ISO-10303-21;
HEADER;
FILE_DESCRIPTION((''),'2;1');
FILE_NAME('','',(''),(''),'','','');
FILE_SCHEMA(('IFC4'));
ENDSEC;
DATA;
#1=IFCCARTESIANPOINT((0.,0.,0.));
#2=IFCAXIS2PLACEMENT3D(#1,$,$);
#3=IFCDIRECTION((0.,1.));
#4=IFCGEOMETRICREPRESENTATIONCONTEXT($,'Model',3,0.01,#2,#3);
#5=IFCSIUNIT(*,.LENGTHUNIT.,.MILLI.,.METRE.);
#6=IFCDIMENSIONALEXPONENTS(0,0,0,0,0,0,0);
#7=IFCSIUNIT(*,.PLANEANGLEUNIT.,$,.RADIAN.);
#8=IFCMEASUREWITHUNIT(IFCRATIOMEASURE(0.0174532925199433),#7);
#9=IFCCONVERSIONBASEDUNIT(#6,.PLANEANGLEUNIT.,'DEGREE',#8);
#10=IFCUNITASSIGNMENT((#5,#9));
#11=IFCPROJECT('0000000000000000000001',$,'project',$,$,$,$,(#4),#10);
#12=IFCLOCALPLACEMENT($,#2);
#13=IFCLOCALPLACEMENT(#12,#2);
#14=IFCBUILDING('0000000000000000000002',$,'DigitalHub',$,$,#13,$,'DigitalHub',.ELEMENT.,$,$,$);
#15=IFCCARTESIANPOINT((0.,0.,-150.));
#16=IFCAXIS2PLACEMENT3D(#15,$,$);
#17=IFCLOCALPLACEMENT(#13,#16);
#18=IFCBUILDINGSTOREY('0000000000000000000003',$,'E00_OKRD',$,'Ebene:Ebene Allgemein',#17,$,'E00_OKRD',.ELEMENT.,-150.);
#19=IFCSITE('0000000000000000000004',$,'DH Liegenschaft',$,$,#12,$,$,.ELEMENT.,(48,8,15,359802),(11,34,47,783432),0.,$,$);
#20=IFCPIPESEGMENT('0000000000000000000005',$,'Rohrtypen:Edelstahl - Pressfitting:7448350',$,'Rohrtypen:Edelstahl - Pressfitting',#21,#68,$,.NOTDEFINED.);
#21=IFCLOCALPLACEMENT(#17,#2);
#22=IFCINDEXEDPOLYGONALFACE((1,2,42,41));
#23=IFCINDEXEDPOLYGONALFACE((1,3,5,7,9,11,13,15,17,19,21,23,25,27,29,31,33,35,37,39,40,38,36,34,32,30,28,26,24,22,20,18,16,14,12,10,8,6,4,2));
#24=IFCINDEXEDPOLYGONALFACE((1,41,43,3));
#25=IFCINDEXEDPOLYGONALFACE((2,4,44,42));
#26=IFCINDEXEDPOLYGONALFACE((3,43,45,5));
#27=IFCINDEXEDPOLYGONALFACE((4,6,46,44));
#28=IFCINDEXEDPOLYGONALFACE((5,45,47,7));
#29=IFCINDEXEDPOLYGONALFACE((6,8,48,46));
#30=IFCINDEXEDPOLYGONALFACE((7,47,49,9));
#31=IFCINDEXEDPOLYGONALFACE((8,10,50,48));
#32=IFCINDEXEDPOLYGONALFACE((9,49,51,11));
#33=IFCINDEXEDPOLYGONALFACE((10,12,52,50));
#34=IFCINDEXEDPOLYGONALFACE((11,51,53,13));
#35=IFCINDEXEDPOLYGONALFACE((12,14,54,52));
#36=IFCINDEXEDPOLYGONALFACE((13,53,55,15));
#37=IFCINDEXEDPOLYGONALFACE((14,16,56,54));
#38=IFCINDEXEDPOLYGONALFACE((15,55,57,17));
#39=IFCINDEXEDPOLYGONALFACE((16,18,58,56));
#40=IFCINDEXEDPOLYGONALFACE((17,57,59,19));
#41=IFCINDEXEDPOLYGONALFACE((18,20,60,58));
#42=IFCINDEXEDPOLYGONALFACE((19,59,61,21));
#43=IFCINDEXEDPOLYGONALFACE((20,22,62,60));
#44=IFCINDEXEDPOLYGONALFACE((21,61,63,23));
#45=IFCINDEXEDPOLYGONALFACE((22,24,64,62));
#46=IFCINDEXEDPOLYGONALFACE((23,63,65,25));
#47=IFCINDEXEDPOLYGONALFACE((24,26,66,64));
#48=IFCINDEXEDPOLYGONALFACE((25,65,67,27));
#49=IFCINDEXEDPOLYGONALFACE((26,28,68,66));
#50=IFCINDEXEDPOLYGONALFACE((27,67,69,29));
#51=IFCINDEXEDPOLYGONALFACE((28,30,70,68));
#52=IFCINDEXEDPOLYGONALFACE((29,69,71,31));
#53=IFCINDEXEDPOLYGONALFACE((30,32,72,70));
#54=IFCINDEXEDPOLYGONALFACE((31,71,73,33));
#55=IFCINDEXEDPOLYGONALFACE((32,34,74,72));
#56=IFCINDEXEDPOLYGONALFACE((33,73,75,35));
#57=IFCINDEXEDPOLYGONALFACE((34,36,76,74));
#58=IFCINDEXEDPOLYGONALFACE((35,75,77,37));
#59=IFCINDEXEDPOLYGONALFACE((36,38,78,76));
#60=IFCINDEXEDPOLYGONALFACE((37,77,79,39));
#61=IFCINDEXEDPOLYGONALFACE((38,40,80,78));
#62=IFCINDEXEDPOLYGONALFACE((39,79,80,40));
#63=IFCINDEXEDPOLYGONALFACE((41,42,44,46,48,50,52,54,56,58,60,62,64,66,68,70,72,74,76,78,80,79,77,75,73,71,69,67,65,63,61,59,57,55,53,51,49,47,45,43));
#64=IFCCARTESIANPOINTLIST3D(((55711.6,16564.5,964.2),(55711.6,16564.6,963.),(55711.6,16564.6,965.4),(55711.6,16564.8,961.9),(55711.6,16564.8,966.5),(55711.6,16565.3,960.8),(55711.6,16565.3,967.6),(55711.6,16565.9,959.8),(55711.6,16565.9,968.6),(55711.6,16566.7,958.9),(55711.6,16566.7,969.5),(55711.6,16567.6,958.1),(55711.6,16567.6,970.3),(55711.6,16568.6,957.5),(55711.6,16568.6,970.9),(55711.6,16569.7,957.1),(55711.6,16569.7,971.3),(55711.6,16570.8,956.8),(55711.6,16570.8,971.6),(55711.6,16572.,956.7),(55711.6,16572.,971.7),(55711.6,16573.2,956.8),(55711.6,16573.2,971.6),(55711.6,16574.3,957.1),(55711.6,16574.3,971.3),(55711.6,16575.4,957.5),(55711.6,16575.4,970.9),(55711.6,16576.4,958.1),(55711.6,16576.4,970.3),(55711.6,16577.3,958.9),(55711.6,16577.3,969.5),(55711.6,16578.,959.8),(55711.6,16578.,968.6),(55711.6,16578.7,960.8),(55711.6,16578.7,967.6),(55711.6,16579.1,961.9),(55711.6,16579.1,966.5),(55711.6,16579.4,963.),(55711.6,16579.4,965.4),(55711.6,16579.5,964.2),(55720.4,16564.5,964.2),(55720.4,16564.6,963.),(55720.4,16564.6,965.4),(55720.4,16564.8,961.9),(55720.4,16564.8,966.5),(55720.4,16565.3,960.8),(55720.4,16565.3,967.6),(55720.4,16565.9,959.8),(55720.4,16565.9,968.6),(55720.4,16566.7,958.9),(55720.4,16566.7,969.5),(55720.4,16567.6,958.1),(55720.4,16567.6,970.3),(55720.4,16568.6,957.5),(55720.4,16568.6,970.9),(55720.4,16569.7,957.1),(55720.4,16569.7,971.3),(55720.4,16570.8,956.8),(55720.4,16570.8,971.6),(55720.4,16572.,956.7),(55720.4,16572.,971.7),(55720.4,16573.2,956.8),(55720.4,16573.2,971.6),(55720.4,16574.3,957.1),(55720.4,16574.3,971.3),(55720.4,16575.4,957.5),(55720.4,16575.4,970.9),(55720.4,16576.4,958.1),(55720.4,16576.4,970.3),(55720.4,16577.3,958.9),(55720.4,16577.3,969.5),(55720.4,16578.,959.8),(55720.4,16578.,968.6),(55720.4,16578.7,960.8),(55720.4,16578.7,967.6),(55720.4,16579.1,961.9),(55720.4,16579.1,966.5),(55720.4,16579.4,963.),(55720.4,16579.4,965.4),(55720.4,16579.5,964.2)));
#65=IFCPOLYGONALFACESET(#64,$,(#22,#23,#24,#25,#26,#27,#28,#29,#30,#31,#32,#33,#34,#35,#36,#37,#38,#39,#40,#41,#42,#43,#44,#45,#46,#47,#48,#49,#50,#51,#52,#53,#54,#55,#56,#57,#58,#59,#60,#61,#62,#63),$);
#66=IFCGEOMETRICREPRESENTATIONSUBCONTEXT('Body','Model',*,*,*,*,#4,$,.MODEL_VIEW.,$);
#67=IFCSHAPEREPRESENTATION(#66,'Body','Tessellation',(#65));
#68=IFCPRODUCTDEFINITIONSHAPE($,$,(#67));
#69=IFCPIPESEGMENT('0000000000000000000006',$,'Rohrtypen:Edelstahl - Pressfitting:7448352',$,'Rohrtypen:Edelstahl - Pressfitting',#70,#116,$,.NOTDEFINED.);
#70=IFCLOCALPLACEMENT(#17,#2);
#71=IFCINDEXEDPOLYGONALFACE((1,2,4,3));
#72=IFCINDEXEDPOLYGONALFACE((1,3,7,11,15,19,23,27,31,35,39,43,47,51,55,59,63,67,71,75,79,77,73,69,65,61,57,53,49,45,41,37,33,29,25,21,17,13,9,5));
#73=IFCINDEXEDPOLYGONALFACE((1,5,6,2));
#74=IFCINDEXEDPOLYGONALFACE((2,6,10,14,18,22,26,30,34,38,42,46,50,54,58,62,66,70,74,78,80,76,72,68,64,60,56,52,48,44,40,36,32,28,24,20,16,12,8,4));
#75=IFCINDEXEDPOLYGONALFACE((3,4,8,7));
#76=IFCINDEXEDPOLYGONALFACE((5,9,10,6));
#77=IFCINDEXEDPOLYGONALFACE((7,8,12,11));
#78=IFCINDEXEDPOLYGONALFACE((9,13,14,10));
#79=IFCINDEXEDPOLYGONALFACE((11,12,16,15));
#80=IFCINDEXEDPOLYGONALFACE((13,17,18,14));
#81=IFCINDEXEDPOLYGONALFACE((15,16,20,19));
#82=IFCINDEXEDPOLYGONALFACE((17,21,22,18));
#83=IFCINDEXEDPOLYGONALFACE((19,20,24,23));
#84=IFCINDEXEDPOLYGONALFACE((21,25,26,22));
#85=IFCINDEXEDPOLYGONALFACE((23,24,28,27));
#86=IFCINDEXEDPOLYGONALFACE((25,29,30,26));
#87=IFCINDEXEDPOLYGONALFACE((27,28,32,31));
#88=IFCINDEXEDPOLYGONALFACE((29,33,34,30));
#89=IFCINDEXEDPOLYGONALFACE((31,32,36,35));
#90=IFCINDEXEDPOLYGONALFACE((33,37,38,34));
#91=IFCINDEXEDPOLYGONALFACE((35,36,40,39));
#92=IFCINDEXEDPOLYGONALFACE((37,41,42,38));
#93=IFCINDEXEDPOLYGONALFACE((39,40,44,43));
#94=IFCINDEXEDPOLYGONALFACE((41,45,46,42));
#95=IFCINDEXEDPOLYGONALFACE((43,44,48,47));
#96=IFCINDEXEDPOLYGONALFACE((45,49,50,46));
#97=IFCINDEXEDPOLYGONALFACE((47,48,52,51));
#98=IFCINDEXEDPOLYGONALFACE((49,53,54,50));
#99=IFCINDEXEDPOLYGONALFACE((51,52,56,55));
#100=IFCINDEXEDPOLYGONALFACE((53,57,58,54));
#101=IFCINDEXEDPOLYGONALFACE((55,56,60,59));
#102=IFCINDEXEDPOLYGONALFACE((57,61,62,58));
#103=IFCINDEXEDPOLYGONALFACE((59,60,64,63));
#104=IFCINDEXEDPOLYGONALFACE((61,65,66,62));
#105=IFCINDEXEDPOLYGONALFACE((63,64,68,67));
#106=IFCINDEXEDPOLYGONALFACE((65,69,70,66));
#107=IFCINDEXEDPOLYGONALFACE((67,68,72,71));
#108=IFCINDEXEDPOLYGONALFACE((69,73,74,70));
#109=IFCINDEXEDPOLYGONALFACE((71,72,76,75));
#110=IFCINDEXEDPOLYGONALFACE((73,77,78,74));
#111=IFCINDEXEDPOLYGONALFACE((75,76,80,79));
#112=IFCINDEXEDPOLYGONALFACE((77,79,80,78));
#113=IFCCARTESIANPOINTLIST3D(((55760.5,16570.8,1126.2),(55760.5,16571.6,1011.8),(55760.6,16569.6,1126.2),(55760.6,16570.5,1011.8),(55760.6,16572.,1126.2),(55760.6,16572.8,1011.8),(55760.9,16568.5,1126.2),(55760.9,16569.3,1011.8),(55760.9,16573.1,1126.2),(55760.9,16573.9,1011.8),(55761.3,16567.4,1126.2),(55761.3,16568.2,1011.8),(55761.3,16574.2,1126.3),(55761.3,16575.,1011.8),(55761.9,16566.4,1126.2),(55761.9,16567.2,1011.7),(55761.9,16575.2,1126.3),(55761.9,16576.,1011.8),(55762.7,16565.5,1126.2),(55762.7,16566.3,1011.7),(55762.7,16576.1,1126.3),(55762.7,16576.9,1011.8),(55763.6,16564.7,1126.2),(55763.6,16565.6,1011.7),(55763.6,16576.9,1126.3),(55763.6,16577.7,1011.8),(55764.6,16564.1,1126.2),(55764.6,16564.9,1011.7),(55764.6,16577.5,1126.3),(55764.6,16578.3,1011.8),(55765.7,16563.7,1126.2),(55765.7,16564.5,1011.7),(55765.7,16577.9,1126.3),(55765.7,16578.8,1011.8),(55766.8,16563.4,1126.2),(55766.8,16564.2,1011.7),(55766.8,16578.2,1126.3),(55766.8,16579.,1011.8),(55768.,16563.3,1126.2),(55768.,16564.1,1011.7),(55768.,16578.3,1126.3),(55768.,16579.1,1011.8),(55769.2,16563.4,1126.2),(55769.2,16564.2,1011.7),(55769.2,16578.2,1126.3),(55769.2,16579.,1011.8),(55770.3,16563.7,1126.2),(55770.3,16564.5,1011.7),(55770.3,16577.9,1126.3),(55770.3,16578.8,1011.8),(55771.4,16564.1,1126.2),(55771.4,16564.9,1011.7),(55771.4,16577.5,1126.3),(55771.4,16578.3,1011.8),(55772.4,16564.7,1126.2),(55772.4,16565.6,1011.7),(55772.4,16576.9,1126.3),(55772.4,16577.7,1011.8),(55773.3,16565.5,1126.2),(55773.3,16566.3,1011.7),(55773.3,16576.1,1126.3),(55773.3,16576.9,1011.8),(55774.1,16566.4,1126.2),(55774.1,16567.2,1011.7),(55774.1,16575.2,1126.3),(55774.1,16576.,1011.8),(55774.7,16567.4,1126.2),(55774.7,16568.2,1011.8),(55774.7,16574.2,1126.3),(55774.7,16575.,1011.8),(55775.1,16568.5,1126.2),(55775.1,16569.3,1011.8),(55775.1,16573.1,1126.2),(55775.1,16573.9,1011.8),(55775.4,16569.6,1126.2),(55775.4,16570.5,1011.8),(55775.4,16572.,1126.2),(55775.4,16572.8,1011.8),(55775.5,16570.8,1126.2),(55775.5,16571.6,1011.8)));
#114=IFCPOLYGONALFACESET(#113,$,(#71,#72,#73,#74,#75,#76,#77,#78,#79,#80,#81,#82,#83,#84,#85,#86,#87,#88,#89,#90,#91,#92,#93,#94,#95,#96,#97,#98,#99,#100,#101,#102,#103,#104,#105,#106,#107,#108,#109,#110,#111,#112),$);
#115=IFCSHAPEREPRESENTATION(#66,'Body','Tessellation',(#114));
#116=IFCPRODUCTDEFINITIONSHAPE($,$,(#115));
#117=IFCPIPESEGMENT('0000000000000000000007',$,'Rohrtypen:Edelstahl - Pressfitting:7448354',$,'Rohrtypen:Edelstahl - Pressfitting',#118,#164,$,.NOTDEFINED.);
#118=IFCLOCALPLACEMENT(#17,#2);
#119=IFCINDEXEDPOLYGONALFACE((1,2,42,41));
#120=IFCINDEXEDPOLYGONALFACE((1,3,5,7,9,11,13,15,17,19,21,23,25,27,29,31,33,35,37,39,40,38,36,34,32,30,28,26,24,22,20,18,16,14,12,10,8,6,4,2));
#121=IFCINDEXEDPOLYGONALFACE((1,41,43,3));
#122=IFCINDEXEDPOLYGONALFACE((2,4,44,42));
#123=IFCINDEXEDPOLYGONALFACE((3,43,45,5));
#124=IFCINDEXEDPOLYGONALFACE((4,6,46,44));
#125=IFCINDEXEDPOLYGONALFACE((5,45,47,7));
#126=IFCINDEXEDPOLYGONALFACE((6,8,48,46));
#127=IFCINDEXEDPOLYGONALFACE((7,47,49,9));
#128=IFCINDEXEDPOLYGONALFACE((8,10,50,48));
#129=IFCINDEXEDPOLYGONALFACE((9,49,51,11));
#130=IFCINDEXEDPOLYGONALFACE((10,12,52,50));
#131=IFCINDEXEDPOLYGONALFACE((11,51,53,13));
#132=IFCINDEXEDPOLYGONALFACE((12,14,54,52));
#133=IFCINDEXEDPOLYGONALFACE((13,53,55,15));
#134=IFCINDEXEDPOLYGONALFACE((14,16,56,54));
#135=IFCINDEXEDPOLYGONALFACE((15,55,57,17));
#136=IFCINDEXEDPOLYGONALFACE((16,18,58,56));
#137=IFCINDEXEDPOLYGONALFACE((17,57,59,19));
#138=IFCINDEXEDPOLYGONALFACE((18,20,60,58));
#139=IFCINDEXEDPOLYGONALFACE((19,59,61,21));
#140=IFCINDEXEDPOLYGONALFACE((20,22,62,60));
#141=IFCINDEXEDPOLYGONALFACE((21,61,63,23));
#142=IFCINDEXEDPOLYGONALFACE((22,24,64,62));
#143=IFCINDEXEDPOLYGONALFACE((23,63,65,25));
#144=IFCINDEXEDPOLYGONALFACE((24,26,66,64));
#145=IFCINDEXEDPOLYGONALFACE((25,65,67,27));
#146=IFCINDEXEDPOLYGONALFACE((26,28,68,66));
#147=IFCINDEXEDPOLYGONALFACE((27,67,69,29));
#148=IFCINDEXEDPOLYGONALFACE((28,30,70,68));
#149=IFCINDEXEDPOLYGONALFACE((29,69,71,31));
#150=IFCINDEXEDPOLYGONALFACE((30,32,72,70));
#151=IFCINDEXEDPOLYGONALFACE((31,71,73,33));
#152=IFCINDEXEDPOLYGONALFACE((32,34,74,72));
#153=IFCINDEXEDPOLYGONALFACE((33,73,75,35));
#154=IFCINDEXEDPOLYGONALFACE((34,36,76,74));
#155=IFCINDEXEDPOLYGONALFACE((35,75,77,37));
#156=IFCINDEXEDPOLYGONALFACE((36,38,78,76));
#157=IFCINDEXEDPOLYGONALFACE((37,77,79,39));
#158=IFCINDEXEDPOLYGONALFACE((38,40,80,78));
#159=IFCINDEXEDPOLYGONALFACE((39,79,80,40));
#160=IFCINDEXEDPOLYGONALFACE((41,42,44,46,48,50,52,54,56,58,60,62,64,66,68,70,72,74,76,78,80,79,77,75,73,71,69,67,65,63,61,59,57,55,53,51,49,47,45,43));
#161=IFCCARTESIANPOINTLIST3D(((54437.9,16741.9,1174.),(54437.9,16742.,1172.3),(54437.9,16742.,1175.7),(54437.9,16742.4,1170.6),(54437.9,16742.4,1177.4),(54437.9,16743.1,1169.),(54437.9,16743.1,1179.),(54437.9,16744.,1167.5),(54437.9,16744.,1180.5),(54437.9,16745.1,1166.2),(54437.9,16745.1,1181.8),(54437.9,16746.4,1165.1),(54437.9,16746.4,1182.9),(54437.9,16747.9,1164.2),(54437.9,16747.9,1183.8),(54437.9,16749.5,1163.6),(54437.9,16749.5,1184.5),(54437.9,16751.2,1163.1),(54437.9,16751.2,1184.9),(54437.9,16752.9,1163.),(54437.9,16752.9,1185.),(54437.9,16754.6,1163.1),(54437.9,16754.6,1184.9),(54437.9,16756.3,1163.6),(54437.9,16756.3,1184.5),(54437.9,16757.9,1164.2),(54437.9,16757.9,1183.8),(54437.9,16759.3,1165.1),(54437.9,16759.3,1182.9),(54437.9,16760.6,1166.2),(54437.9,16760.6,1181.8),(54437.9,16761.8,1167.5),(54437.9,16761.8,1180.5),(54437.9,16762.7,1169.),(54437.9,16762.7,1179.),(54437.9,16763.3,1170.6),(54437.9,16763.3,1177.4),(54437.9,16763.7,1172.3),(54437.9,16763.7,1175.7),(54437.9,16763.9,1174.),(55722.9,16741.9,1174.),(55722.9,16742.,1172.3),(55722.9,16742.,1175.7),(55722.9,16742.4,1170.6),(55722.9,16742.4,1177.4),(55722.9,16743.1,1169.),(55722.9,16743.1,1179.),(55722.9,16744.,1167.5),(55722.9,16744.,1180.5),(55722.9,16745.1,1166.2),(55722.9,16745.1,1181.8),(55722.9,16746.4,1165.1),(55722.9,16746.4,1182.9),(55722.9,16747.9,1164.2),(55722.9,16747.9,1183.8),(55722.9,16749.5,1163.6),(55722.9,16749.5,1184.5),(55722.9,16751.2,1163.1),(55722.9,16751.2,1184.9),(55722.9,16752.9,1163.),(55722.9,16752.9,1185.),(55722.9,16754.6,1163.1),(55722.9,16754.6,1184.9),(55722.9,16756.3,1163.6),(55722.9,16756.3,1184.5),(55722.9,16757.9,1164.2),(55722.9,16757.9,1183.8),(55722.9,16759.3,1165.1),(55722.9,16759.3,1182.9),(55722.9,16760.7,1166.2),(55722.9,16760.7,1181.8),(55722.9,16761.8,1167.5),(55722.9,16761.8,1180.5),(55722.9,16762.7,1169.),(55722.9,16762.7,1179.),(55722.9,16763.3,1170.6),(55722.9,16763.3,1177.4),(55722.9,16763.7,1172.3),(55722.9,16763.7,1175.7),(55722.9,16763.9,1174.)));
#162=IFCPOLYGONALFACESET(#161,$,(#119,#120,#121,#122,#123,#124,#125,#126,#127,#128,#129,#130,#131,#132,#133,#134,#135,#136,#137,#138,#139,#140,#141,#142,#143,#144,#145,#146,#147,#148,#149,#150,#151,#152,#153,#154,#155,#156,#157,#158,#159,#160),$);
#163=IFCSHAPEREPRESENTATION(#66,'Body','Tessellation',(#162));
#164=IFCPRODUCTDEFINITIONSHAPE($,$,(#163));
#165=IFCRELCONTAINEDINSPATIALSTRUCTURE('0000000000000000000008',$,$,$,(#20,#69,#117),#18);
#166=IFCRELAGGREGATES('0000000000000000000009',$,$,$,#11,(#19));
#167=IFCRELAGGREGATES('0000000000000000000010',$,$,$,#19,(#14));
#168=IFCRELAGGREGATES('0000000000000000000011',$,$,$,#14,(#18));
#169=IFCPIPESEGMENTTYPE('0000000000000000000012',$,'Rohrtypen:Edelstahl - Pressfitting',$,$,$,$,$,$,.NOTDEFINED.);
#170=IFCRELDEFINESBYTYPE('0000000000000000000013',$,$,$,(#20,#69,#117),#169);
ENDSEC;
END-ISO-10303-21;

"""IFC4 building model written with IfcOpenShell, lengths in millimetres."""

from ifc_helpers import new_model, entity, si_unit, converted_unit, direction, frame, origin, place, context, subcontext, project, spatial, indexed_curve, outline, extrude, type_object, element, save


model = new_model("IFC4")

# Units and contexts
model_context = context("Model", 3, precision=0.01, world=origin(), true_north=direction((0.0, 1.0)))
body_context = subcontext(model_context, "Body", "Model", "MODEL_VIEW")
ifc_project = project(units=[si_unit("LENGTHUNIT", "METRE", prefix="MILLI"), converted_unit("PLANEANGLEUNIT", "DEGREE", entity("IfcRatioMeasure", 0.0174532925199433), si_unit("PLANEANGLEUNIT", "RADIAN"), dimensions=[0, 0, 0, 0, 0, 0, 0])], contexts=[model_context])

# Site, building, storey
site_placement = place(None, origin())
site = spatial("IfcSite", under=ifc_project, at=site_placement, Name="DH Liegenschaft", CompositionType="ELEMENT", RefLatitude=(48, 8, 15, 359802), RefLongitude=(11, 34, 47, 783432), RefElevation=0.0)
building_placement = place(site_placement, origin())
building = spatial("IfcBuilding", under=site, at=building_placement, Name="DigitalHub", LongName="DigitalHub", CompositionType="ELEMENT")
storey_placement = place(building_placement, frame((0.0, 0.0, -150.0)))
storey = spatial("IfcBuildingStorey", under=building, at=storey_placement, Name="E00_OKRD", ObjectType="Ebene:Ebene Allgemein", LongName="E00_OKRD", CompositionType="ELEMENT", Elevation=-150.0)

# Pipe segments
pipe_segment_type_1 = type_object("IfcPipeSegmentType", Name="Rohrtypen:Edelstahl - Pressfitting", PredefinedType="NOTDEFINED")
pipe_segment_1_placement = place(storey_placement, frame((55711.6, 16562.9, 955.1)))
element("IfcPipeSegment", 1, at=pipe_segment_1_placement, inside=storey, type_object=pipe_segment_type_1, Name="Rohrtypen:Edelstahl - Pressfitting:7448350", ObjectType="Rohrtypen:Edelstahl - Pressfitting", PredefinedType="NOTDEFINED", context=body_context, shape_type="SweptSolid", body=[
    extrude(outline(indexed_curve([(7.5, 0.0), (7.4, 1.2), (7.1, 2.3), (6.7, 3.4), (6.1, 4.4), (5.3, 5.3), (4.4, 6.1), (3.4, 6.7), (2.3, 7.1), (1.2, 7.4), (0.0, 7.5), (-1.2, 7.4), (-2.3, 7.1), (-3.4, 6.7), (-4.4, 6.1), (-5.3, 5.3), (-6.1, 4.4), (-6.7, 3.4), (-7.1, 2.3), (-7.4, 1.2), (-7.5, 0.0), (-7.4, -1.2), (-7.1, -2.3), (-6.7, -3.4), (-6.1, -4.4), (-5.3, -5.3), (-4.4, -6.1), (-3.4, -6.7), (-2.3, -7.1), (-1.2, -7.4), (0.0, -7.5), (1.2, -7.4), (2.3, -7.1), (3.4, -6.7), (4.4, -6.1), (5.3, -5.3), (6.1, -4.4), (6.7, -3.4), (7.1, -2.3), (7.4, -1.2), (7.5, 0.0)], self_intersect=False)), frame((0.0, 9.1, 9.1), z_axis=(1.0, -0.000009, 0.0), x_axis=(-0.000009, -1.0, 0.0)), (0.0, 0.0, 1.0), 8.8),
])
pipe_segment_2_placement = place(storey_placement, frame((55758.9, 16561.7, 1011.7)))
element("IfcPipeSegment", 2, at=pipe_segment_2_placement, inside=storey, type_object=pipe_segment_type_1, Name="Rohrtypen:Edelstahl - Pressfitting:7448352", ObjectType="Rohrtypen:Edelstahl - Pressfitting", PredefinedType="NOTDEFINED", context=body_context, shape_type="SweptSolid", body=[
    extrude(outline(indexed_curve([(7.5, 0.0), (7.4, 1.2), (7.1, 2.3), (6.7, 3.4), (6.1, 4.4), (5.3, 5.3), (4.4, 6.1), (3.4, 6.7), (2.3, 7.1), (1.2, 7.4), (0.0, 7.5), (-1.2, 7.4), (-2.3, 7.1), (-3.4, 6.7), (-4.4, 6.1), (-5.3, 5.3), (-6.1, 4.4), (-6.7, 3.4), (-7.1, 2.3), (-7.4, 1.2), (-7.5, 0.0), (-7.4, -1.2), (-7.1, -2.3), (-6.7, -3.4), (-6.1, -4.4), (-5.3, -5.3), (-4.4, -6.1), (-3.4, -6.7), (-2.3, -7.1), (-1.2, -7.4), (0.0, -7.5), (1.2, -7.4), (2.3, -7.1), (3.4, -6.7), (4.4, -6.1), (5.3, -5.3), (6.1, -4.4), (6.7, -3.4), (7.1, -2.3), (7.4, -1.2), (7.5, 0.0)], self_intersect=False)), frame((9.1, 9.9, 0.1), z_axis=(0.0, -0.007378, 0.999973), x_axis=(-1.0, 0.0, 0.0)), (0.0, 0.0, 1.0), 114.4),
])
pipe_segment_3_placement = place(storey_placement, frame((54437.9, 16740.3, 1161.4)))
element("IfcPipeSegment", 3, at=pipe_segment_3_placement, inside=storey, type_object=pipe_segment_type_1, Name="Rohrtypen:Edelstahl - Pressfitting:7448354", ObjectType="Rohrtypen:Edelstahl - Pressfitting", PredefinedType="NOTDEFINED", context=body_context, shape_type="SweptSolid", body=[
    extrude(outline(indexed_curve([(11.0, 0.0), (10.9, 1.7), (10.5, 3.4), (9.8, 5.0), (8.9, 6.5), (7.8, 7.8), (6.5, 8.9), (5.0, 9.8), (3.4, 10.5), (1.7, 10.9), (0.0, 11.0), (-1.7, 10.9), (-3.4, 10.5), (-5.0, 9.8), (-6.5, 8.9), (-7.8, 7.8), (-8.9, 6.5), (-9.8, 5.0), (-10.5, 3.4), (-10.9, 1.7), (-11.0, 0.0), (-10.9, -1.7), (-10.5, -3.4), (-9.8, -5.0), (-8.9, -6.5), (-7.8, -7.8), (-6.5, -8.9), (-5.0, -9.8), (-3.4, -10.5), (-1.7, -10.9), (0.0, -11.0), (1.7, -10.9), (3.4, -10.5), (5.0, -9.8), (6.5, -8.9), (7.8, -7.8), (8.9, -6.5), (9.8, -5.0), (10.5, -3.4), (10.9, -1.7), (11.0, 0.0)], self_intersect=False)), frame((0.0, 12.6, 12.6), z_axis=(1.0, 0.000001, 0.0), x_axis=(-0.000001, 1.0, 0.0)), (0.0, 0.0, 1.0), 1285.0),
])

save(model, "model.ifc")
